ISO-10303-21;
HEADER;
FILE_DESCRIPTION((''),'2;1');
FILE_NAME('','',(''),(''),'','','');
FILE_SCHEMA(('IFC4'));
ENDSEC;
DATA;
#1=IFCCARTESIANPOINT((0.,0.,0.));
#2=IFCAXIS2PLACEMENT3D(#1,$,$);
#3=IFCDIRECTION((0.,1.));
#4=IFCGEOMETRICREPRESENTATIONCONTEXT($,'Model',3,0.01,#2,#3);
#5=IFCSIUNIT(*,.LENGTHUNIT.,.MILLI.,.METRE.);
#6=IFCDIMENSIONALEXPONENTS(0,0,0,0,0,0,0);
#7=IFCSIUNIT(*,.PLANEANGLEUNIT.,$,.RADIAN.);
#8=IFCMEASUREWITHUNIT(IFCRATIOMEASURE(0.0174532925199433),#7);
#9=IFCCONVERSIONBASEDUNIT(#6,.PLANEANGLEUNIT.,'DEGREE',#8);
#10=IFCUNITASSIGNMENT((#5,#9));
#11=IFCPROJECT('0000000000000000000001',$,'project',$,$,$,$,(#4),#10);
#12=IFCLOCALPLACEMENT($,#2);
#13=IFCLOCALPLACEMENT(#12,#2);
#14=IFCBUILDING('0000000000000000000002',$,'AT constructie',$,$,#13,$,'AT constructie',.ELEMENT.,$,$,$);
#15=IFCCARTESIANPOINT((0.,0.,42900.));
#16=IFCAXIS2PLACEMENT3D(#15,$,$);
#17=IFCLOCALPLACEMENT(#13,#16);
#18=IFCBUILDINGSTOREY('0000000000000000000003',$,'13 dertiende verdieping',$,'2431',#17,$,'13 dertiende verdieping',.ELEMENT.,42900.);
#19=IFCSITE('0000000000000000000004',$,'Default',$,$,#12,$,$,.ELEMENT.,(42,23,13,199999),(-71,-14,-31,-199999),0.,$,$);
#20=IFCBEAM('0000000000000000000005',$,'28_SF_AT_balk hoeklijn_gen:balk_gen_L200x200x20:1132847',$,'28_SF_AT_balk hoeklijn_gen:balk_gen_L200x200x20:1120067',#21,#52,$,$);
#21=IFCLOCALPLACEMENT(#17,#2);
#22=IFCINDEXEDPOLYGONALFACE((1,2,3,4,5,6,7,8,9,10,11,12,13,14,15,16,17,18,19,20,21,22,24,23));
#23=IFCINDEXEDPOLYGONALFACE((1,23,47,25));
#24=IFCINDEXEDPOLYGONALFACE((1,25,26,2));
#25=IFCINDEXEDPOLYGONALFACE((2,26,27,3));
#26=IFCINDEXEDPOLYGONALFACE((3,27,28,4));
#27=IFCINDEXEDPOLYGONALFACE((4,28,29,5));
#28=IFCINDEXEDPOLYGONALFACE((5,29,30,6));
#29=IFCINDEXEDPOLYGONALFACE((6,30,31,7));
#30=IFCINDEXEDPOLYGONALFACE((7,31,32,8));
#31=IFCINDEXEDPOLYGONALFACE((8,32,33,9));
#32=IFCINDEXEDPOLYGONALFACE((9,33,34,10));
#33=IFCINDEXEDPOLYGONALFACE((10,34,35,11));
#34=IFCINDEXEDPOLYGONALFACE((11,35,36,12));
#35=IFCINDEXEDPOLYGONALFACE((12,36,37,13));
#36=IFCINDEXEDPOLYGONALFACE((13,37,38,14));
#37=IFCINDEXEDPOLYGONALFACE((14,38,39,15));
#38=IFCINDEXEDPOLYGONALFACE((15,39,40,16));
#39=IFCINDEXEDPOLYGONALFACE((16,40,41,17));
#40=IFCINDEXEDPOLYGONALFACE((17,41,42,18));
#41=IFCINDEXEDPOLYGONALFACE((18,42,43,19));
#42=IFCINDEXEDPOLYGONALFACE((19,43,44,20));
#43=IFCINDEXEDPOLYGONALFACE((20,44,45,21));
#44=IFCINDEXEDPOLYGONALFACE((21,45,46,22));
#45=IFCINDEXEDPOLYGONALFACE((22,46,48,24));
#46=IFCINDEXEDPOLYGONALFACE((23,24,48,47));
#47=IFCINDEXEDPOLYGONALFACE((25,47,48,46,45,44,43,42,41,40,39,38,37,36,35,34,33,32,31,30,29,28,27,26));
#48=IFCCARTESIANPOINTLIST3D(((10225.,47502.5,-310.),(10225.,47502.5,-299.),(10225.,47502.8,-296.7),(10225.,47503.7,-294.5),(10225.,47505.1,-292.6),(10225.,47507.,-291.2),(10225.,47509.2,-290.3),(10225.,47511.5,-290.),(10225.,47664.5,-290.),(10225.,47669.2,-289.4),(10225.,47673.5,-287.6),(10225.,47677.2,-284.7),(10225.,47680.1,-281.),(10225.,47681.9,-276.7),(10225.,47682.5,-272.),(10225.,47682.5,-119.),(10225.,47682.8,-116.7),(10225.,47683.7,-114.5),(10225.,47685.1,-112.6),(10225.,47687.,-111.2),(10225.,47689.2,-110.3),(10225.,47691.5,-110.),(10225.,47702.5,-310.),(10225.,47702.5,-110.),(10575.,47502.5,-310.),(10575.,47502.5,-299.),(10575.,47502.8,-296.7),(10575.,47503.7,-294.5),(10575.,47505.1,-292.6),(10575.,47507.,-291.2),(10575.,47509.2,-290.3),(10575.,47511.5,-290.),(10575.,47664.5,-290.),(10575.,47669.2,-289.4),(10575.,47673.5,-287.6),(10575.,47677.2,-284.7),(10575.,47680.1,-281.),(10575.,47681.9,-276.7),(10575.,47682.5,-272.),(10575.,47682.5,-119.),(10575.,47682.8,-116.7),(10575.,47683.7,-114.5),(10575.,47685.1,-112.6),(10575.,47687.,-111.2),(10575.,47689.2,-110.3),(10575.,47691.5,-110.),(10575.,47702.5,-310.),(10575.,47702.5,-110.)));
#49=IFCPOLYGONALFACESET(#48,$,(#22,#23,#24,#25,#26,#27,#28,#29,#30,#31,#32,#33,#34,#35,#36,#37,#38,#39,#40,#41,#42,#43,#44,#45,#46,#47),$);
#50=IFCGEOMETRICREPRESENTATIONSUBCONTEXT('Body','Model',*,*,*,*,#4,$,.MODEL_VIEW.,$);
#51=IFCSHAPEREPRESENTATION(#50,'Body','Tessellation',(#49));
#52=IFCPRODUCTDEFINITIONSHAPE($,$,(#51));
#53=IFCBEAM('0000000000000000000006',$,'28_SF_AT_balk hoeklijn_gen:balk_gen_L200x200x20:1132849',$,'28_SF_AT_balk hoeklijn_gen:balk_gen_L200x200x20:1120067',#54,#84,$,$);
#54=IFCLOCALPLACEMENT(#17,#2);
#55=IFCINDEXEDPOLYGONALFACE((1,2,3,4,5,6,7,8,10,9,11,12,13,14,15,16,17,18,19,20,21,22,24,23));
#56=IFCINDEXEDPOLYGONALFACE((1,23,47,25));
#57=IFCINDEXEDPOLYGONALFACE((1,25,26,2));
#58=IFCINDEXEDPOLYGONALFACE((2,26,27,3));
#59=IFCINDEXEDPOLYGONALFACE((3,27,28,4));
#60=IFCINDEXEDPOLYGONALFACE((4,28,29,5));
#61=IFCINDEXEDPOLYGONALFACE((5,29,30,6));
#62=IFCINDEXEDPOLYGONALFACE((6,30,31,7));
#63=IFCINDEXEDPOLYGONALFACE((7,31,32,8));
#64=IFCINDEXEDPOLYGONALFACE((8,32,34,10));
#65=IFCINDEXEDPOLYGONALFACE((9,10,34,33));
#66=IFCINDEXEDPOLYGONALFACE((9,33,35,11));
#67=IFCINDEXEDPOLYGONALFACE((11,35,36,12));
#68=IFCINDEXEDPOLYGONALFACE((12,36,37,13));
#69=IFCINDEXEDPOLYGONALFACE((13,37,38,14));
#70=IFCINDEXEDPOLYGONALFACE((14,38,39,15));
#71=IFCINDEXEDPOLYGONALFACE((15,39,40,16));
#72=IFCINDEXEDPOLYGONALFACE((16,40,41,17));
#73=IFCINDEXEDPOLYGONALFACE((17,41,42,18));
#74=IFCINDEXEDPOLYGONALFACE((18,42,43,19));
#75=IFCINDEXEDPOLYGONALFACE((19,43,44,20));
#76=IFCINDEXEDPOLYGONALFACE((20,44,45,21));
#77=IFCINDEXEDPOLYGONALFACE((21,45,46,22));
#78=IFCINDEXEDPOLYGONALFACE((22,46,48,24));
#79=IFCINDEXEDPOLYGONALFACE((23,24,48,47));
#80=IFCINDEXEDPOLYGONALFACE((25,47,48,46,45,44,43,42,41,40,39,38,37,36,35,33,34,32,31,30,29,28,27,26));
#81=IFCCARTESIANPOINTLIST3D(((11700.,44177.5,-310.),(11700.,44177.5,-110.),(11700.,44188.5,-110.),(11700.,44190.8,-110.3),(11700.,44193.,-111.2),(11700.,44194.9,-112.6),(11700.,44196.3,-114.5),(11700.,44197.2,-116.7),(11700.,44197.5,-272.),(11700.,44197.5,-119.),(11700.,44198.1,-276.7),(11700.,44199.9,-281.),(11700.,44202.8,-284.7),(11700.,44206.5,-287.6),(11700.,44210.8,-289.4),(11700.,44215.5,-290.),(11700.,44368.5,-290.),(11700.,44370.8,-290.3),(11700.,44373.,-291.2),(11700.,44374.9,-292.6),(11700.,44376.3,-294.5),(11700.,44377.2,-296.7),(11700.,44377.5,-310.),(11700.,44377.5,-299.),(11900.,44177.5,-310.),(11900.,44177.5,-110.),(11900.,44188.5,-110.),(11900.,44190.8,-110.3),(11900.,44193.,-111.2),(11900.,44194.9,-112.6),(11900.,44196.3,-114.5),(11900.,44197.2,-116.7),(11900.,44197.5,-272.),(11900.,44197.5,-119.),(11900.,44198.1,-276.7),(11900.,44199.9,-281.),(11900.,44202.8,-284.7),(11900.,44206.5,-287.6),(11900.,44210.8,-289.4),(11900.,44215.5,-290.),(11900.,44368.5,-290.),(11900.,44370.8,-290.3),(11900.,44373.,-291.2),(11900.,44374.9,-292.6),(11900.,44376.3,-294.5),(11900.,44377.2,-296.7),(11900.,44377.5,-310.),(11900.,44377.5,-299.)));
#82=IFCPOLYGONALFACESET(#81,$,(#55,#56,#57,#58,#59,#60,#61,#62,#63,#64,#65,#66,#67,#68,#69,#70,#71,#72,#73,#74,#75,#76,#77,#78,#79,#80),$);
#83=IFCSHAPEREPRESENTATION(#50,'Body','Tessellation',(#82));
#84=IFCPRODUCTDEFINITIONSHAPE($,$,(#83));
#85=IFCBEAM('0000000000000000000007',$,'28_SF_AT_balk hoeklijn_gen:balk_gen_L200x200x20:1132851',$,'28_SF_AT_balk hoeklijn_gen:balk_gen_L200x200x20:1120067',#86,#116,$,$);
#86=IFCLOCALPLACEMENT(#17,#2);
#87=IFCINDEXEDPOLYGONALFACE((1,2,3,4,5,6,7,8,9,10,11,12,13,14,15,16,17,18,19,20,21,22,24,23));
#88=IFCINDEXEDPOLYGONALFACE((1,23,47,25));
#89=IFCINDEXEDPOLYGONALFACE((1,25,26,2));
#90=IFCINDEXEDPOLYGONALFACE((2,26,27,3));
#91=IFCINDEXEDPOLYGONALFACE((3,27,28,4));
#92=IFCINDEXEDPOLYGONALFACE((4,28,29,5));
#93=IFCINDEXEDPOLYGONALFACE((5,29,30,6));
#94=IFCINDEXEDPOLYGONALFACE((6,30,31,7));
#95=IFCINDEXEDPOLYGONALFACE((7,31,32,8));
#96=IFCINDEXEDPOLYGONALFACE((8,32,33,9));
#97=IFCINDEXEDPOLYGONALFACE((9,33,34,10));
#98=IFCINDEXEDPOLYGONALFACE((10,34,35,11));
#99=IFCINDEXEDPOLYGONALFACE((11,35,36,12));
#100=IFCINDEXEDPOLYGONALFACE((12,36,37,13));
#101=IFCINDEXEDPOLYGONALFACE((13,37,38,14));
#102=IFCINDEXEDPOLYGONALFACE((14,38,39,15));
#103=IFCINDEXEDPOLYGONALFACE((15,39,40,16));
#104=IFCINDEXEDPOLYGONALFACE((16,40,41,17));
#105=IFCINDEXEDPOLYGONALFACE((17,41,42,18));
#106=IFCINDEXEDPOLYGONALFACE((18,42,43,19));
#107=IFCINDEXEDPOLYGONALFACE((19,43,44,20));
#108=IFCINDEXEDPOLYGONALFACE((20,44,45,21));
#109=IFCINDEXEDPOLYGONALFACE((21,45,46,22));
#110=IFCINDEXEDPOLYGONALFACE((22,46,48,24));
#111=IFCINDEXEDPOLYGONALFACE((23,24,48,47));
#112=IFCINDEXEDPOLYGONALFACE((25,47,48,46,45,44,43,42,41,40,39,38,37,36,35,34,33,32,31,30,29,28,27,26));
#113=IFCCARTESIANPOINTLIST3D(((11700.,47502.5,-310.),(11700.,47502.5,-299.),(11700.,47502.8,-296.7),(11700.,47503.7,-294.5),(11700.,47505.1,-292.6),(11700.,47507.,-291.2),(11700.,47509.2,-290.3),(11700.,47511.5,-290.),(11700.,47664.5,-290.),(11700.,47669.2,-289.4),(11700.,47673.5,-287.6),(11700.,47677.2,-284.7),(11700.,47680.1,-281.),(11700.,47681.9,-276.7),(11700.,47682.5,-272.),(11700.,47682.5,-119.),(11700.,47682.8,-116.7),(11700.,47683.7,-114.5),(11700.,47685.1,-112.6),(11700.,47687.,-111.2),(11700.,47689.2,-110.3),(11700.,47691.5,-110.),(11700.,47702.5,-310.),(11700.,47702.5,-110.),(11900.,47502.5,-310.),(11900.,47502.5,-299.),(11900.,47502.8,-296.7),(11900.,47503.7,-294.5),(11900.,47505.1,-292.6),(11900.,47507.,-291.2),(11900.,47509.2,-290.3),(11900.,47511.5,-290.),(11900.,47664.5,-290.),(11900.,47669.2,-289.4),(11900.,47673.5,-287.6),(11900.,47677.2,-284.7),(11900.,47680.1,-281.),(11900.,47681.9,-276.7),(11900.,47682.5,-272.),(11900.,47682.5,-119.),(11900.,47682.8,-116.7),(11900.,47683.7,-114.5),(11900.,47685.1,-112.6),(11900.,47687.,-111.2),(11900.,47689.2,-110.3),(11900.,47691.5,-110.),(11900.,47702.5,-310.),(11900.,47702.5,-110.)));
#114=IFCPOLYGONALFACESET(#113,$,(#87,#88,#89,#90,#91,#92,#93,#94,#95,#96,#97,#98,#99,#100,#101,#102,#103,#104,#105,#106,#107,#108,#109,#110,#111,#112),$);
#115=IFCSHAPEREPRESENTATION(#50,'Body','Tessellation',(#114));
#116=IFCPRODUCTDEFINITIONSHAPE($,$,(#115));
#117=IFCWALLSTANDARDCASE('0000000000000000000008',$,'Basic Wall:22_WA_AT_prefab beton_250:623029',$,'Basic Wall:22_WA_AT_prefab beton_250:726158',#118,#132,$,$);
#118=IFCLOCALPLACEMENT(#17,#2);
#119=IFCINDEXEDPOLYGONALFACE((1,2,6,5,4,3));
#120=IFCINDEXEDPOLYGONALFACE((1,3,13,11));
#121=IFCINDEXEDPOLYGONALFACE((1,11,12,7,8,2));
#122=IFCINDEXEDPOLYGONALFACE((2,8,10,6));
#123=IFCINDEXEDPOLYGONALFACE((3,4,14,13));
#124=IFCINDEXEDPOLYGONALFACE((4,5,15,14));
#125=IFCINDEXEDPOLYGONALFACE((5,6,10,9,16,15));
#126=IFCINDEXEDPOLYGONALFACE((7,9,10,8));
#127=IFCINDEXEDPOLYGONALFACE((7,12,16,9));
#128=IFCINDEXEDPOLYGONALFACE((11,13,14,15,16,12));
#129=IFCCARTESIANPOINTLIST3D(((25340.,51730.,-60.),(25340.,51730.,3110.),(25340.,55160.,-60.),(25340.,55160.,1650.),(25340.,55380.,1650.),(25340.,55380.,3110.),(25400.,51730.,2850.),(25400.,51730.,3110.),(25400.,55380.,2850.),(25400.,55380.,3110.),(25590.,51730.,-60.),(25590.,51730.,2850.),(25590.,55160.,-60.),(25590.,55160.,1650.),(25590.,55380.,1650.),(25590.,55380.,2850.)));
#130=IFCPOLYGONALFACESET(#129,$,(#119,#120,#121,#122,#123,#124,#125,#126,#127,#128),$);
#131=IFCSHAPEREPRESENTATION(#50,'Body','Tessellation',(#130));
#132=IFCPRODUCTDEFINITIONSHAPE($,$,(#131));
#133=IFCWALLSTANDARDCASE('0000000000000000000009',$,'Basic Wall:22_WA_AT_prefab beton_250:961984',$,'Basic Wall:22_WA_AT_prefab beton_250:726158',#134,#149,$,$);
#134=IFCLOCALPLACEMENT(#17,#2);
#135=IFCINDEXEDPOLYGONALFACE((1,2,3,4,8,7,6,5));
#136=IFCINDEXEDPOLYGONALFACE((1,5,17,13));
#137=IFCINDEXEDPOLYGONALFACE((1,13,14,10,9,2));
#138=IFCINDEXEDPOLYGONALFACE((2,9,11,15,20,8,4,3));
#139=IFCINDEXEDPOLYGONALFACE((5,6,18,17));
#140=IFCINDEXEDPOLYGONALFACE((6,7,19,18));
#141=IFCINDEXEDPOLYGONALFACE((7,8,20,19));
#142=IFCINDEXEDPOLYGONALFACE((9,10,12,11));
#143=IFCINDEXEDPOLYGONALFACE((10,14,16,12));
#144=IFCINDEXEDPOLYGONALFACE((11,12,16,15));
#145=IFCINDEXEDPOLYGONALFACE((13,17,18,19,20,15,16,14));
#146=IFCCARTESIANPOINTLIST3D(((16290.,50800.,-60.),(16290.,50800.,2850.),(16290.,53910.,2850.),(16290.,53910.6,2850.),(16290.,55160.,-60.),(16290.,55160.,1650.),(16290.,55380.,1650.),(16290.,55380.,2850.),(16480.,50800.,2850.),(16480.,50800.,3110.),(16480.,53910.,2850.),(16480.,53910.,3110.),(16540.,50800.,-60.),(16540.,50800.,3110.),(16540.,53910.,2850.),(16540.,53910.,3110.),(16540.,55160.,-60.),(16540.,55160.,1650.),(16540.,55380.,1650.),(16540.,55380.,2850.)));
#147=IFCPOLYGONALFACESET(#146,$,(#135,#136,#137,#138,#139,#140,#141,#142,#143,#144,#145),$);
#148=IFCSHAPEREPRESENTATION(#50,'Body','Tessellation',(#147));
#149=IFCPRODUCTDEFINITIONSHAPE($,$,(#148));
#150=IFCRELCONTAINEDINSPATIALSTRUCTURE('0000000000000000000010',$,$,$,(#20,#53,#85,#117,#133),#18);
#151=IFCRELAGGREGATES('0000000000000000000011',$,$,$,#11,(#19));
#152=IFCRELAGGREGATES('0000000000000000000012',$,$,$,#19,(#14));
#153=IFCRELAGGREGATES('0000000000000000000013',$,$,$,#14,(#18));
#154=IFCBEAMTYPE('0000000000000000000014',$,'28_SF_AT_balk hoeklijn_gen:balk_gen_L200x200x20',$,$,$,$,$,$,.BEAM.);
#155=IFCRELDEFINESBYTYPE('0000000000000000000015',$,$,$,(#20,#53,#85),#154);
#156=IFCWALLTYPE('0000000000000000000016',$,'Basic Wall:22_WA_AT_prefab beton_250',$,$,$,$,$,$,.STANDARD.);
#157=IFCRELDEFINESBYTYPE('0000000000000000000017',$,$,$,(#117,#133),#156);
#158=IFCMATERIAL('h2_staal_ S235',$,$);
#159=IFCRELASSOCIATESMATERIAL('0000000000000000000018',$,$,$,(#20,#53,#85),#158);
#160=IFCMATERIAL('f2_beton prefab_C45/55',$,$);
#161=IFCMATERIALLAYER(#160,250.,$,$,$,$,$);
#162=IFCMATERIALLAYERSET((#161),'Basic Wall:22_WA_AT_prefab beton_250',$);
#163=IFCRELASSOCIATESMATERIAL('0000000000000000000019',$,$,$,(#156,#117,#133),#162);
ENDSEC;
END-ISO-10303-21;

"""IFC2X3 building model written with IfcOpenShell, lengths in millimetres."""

from ifc_helpers import new_model, entity, si_unit, converted_unit, direction, frame, frame_2d, origin, place, context, subcontext, project, spatial, polyline, circle_curve, parameter, trimmed, segment, composite_curve, rectangle, outline, extrude, material, layer, layer_set, layer_usage, type_object, element, save


model = new_model("IFC2X3")

# Units and contexts
model_context = context("Model", 3, precision=0.01, world=origin(), true_north=direction((0.0, 1.0)))
body_context = subcontext(model_context, "Body", "Model", "MODEL_VIEW")
ifc_project = project(units=[si_unit("LENGTHUNIT", "METRE", prefix="MILLI"), converted_unit("PLANEANGLEUNIT", "DEGREE", entity("IfcRatioMeasure", 0.0174532925199433), si_unit("PLANEANGLEUNIT", "RADIAN"), dimensions=[0, 0, 0, 0, 0, 0, 0])], contexts=[model_context])

# Site, building, storey
site_placement = place(None, origin())
site = spatial("IfcSite", under=ifc_project, at=site_placement, Name="Default", CompositionType="ELEMENT", RefLatitude=(42, 23, 13, 199999), RefLongitude=(-71, -14, -31, -199999), RefElevation=0.0)
building_placement = place(site_placement, origin())
building = spatial("IfcBuilding", under=site, at=building_placement, Name="AT constructie", LongName="AT constructie", CompositionType="ELEMENT")
storey_placement = place(building_placement, frame((0.0, 0.0, 42900.0)))
storey = spatial("IfcBuildingStorey", under=building, at=storey_placement, Name="13 dertiende verdieping", ObjectType="2431", LongName="13 dertiende verdieping", CompositionType="ELEMENT", Elevation=42900.0)

# Beams
ifc_material_1 = material(Name="h2_staal_ S235")
beam_type_1 = type_object("IfcBeamType", Name="28_SF_AT_balk hoeklijn_gen:balk_gen_L200x200x20", PredefinedType="BEAM")
beam_1_placement = place(storey_placement, frame((10575.0, 47702.5, -70.0), z_axis=(0.0, 0.0, 1.0), x_axis=(-1.0, 0.0, 0.0)))
element("IfcBeam", 1, at=beam_1_placement, inside=storey, type_object=beam_type_1, material=ifc_material_1, Name="28_SF_AT_balk hoeklijn_gen:balk_gen_L200x200x20:1132847", ObjectType="28_SF_AT_balk hoeklijn_gen:balk_gen_L200x200x20:1120067", context=body_context, shape_type="SweptSolid", body=[
    extrude(outline(composite_curve([segment(polyline([(-124.4, -75.6), (75.6, -75.6)]), True, "CONTINUOUS"), segment(polyline([(75.6, -75.6), (75.6, 124.4)]), True, "CONTINUOUS"), segment(polyline([(75.6, 124.4), (64.6, 124.4)]), True, "CONTINUOUS"), segment(trimmed(circle_curve(frame_2d((64.6, 115.4), x_axis=(0.0, 1.0)), 9.0), [parameter(0.0)], [parameter(90.0)], True, "PARAMETER"), True, "CONTINUOUS"), segment(polyline([(55.6, 115.4), (55.6, -37.6)]), True, "CONTINUOUS"), segment(trimmed(circle_curve(frame_2d((37.6, -37.6), x_axis=(1.0, 0.0)), 18.0), [parameter(270.0)], [parameter(0.0)], True, "PARAMETER"), False, "CONTINUOUS"), segment(polyline([(37.6, -55.6), (-115.4, -55.6)]), True, "CONTINUOUS"), segment(trimmed(circle_curve(frame_2d((-115.4, -64.6), x_axis=(0.0, 1.0)), 9.0), [parameter(0.0)], [parameter(90.0)], True, "PARAMETER"), True, "CONTINUOUS"), segment(polyline([(-124.4, -64.6), (-124.4, -75.6)]), True, "CONTINUOUS")], self_intersect=False)), frame((0.0, 75.6, -164.4), z_axis=(1.0, 0.0, 0.0), x_axis=(0.0, 0.0, -1.0)), (0.0, 0.0, 1.0), 350.0),
])
beam_2_placement = place(storey_placement, frame((11700.0, 44177.5, -70.0)))
element("IfcBeam", 2, at=beam_2_placement, inside=storey, type_object=beam_type_1, material=ifc_material_1, Name="28_SF_AT_balk hoeklijn_gen:balk_gen_L200x200x20:1132849", ObjectType="28_SF_AT_balk hoeklijn_gen:balk_gen_L200x200x20:1120067", context=body_context, shape_type="SweptSolid", body=[
    extrude(outline(composite_curve([segment(polyline([(-124.4, -75.6), (75.6, -75.6)]), True, "CONTINUOUS"), segment(polyline([(75.6, -75.6), (75.6, 124.4)]), True, "CONTINUOUS"), segment(polyline([(75.6, 124.4), (64.6, 124.4)]), True, "CONTINUOUS"), segment(trimmed(circle_curve(frame_2d((64.6, 115.4), x_axis=(0.0, 1.0)), 9.0), [parameter(0.0)], [parameter(90.0)], True, "PARAMETER"), True, "CONTINUOUS"), segment(polyline([(55.6, 115.4), (55.6, -37.6)]), True, "CONTINUOUS"), segment(trimmed(circle_curve(frame_2d((37.6, -37.6), x_axis=(1.0, 0.0)), 18.0), [parameter(270.0)], [parameter(0.0)], True, "PARAMETER"), False, "CONTINUOUS"), segment(polyline([(37.6, -55.6), (-115.4, -55.6)]), True, "CONTINUOUS"), segment(trimmed(circle_curve(frame_2d((-115.4, -64.6), x_axis=(0.0, 1.0)), 9.0), [parameter(0.0)], [parameter(90.0)], True, "PARAMETER"), True, "CONTINUOUS"), segment(polyline([(-124.4, -64.6), (-124.4, -75.6)]), True, "CONTINUOUS")], self_intersect=False)), frame((0.0, 75.6, -164.4), z_axis=(1.0, 0.0, 0.0), x_axis=(0.0, 0.0, -1.0)), (0.0, 0.0, 1.0), 200.0),
])
beam_3_placement = place(storey_placement, frame((11900.0, 47702.5, -70.0), z_axis=(0.0, 0.0, 1.0), x_axis=(-1.0, 0.0, 0.0)))
element("IfcBeam", 3, at=beam_3_placement, inside=storey, type_object=beam_type_1, material=ifc_material_1, Name="28_SF_AT_balk hoeklijn_gen:balk_gen_L200x200x20:1132851", ObjectType="28_SF_AT_balk hoeklijn_gen:balk_gen_L200x200x20:1120067", context=body_context, shape_type="SweptSolid", body=[
    extrude(outline(composite_curve([segment(polyline([(-124.4, -75.6), (75.6, -75.6)]), True, "CONTINUOUS"), segment(polyline([(75.6, -75.6), (75.6, 124.4)]), True, "CONTINUOUS"), segment(polyline([(75.6, 124.4), (64.6, 124.4)]), True, "CONTINUOUS"), segment(trimmed(circle_curve(frame_2d((64.6, 115.4), x_axis=(0.0, 1.0)), 9.0), [parameter(0.0)], [parameter(90.0)], True, "PARAMETER"), True, "CONTINUOUS"), segment(polyline([(55.6, 115.4), (55.6, -37.6)]), True, "CONTINUOUS"), segment(trimmed(circle_curve(frame_2d((37.6, -37.6), x_axis=(1.0, 0.0)), 18.0), [parameter(270.0)], [parameter(0.0)], True, "PARAMETER"), False, "CONTINUOUS"), segment(polyline([(37.6, -55.6), (-115.4, -55.6)]), True, "CONTINUOUS"), segment(trimmed(circle_curve(frame_2d((-115.4, -64.6), x_axis=(0.0, 1.0)), 9.0), [parameter(0.0)], [parameter(90.0)], True, "PARAMETER"), True, "CONTINUOUS"), segment(polyline([(-124.4, -64.6), (-124.4, -75.6)]), True, "CONTINUOUS")], self_intersect=False)), frame((0.0, 75.6, -164.4), z_axis=(1.0, 0.0, 0.0), x_axis=(0.0, 0.0, -1.0)), (0.0, 0.0, 1.0), 200.0),
])

# Walls, openings
ifc_material_2 = material(Name="f2_beton prefab_C45/55")
ifc_layer = layer(ifc_material_2, 250.0)
ifc_layer_set = layer_set([ifc_layer], Name="Basic Wall:22_WA_AT_prefab beton_250")
ifc_layer_usage_1 = layer_usage(ifc_layer_set, "AXIS2", "NEGATIVE", 125.0)
wall_type = type_object("IfcWallType", Name="Basic Wall:22_WA_AT_prefab beton_250", PredefinedType="STANDARD", material=ifc_layer_set)
wall_1_placement = place(storey_placement, frame((25465.0, 55380.0, -60.0), z_axis=(0.0, 0.0, 1.0), x_axis=(0.0, -1.0, 0.0)))
wall_1 = element("IfcWallStandardCase", 4, at=wall_1_placement, inside=storey, type_object=wall_type, material=ifc_layer_usage_1, Name="Basic Wall:22_WA_AT_prefab beton_250:623029", ObjectType="Basic Wall:22_WA_AT_prefab beton_250:726158", context=body_context, shape_type="SweptSolid", body=[
    extrude(rectangle(XDim=3650.0, YDim=250.0, at=frame_2d((1825.0, 0.0), x_axis=(-1.0, 0.0))), origin(), (0.0, 0.0, 1.0), 3170.0),
])
opening_1_placement = place(wall_1_placement, origin())
element("IfcOpeningElement", 5, at=opening_1_placement, cuts=wall_1, ObjectType="Recess", context=body_context, shape_type="SweptSolid", body=[
    extrude(rectangle(XDim=260.0, YDim=3900.0, at=frame_2d((0.0, 0.0), x_axis=(0.0, 1.0))), frame((1950.0, -65.0, 3040.0), z_axis=(0.0, 1.0, 0.0), x_axis=(1.0, 0.0, 0.0)), (0.0, 0.0, 1.0), 190.0),
])
opening_2_placement = place(wall_1_placement, origin())
element("IfcOpeningElement", 6, at=opening_2_placement, cuts=wall_1, ObjectType="Opening", context=body_context, shape_type="SweptSolid", body=[
    extrude(rectangle(XDim=1710.0, YDim=220.0, at=frame_2d((0.0, 0.0), x_axis=(1.0, 0.0))), frame((110.0, 125.0, 855.0), z_axis=(0.0, -1.0, 0.0), x_axis=(0.0, 0.0, -1.0)), (0.0, 0.0, 1.0), 250.0),
])
ifc_layer_usage_2 = layer_usage(ifc_layer_set, "AXIS2", "NEGATIVE", 125.0)
wall_2_placement = place(storey_placement, frame((16415.0, 55380.0, -60.0), z_axis=(0.0, 0.0, 1.0), x_axis=(0.0, -1.0, 0.0)))
wall_2 = element("IfcWallStandardCase", 7, at=wall_2_placement, inside=storey, type_object=wall_type, material=ifc_layer_usage_2, Name="Basic Wall:22_WA_AT_prefab beton_250:961984", ObjectType="Basic Wall:22_WA_AT_prefab beton_250:726158", context=body_context, shape_type="SweptSolid", body=[
    extrude(rectangle(XDim=4580.0, YDim=250.0, at=frame_2d((2290.0, 0.0), x_axis=(-1.0, 0.0))), origin(), (0.0, 0.0, 1.0), 3170.0),
])
opening_3_placement = place(wall_2_placement, origin())
element("IfcOpeningElement", 8, at=opening_3_placement, cuts=wall_2, ObjectType="Recess", context=body_context, shape_type="SweptSolid", body=[
    extrude(rectangle(XDim=260.0, YDim=3230.6, at=frame_2d((0.0, 0.0), x_axis=(1.0, 0.0))), frame((3084.7, -125.0, 3040.0), z_axis=(0.0, 1.0, 0.0), x_axis=(0.0, 0.0, -1.0)), (0.0, 0.0, 1.0), 190.0),
])
opening_4_placement = place(wall_2_placement, origin())
element("IfcOpeningElement", 9, at=opening_4_placement, cuts=wall_2, ObjectType="Opening", context=body_context, shape_type="SweptSolid", body=[
    extrude(rectangle(XDim=260.0, YDim=190.0, at=frame_2d((0.0, 0.0), x_axis=(0.0, 1.0))), frame((4735.0, -125.0, 3040.0), z_axis=(0.0, 1.0, 0.0), x_axis=(-1.0, 0.0, 0.0)), (0.0, 0.0, 1.0), 2350.0),
])
opening_5_placement = place(wall_2_placement, origin())
element("IfcOpeningElement", 10, at=opening_5_placement, cuts=wall_2, ObjectType="Opening", context=body_context, shape_type="SweptSolid", body=[
    extrude(rectangle(XDim=260.0, YDim=1470.0, at=frame_2d((0.0, 0.0), x_axis=(0.0, 1.0))), frame((735.0, 125.0, 3040.0), z_axis=(0.0, -1.0, 0.0), x_axis=(-1.0, 0.0, 0.0)), (0.0, 0.0, 1.0), 250.0),
])
opening_6_placement = place(wall_2_placement, origin())
element("IfcOpeningElement", 11, at=opening_6_placement, cuts=wall_2, ObjectType="Opening", context=body_context, shape_type="SweptSolid", body=[
    extrude(rectangle(XDim=1710.0, YDim=220.0, at=frame_2d((0.0, 0.0), x_axis=(1.0, 0.0))), frame((110.0, 125.0, 855.0), z_axis=(0.0, -1.0, 0.0), x_axis=(0.0, 0.0, -1.0)), (0.0, 0.0, 1.0), 250.0),
])

save(model, "model.ifc")
